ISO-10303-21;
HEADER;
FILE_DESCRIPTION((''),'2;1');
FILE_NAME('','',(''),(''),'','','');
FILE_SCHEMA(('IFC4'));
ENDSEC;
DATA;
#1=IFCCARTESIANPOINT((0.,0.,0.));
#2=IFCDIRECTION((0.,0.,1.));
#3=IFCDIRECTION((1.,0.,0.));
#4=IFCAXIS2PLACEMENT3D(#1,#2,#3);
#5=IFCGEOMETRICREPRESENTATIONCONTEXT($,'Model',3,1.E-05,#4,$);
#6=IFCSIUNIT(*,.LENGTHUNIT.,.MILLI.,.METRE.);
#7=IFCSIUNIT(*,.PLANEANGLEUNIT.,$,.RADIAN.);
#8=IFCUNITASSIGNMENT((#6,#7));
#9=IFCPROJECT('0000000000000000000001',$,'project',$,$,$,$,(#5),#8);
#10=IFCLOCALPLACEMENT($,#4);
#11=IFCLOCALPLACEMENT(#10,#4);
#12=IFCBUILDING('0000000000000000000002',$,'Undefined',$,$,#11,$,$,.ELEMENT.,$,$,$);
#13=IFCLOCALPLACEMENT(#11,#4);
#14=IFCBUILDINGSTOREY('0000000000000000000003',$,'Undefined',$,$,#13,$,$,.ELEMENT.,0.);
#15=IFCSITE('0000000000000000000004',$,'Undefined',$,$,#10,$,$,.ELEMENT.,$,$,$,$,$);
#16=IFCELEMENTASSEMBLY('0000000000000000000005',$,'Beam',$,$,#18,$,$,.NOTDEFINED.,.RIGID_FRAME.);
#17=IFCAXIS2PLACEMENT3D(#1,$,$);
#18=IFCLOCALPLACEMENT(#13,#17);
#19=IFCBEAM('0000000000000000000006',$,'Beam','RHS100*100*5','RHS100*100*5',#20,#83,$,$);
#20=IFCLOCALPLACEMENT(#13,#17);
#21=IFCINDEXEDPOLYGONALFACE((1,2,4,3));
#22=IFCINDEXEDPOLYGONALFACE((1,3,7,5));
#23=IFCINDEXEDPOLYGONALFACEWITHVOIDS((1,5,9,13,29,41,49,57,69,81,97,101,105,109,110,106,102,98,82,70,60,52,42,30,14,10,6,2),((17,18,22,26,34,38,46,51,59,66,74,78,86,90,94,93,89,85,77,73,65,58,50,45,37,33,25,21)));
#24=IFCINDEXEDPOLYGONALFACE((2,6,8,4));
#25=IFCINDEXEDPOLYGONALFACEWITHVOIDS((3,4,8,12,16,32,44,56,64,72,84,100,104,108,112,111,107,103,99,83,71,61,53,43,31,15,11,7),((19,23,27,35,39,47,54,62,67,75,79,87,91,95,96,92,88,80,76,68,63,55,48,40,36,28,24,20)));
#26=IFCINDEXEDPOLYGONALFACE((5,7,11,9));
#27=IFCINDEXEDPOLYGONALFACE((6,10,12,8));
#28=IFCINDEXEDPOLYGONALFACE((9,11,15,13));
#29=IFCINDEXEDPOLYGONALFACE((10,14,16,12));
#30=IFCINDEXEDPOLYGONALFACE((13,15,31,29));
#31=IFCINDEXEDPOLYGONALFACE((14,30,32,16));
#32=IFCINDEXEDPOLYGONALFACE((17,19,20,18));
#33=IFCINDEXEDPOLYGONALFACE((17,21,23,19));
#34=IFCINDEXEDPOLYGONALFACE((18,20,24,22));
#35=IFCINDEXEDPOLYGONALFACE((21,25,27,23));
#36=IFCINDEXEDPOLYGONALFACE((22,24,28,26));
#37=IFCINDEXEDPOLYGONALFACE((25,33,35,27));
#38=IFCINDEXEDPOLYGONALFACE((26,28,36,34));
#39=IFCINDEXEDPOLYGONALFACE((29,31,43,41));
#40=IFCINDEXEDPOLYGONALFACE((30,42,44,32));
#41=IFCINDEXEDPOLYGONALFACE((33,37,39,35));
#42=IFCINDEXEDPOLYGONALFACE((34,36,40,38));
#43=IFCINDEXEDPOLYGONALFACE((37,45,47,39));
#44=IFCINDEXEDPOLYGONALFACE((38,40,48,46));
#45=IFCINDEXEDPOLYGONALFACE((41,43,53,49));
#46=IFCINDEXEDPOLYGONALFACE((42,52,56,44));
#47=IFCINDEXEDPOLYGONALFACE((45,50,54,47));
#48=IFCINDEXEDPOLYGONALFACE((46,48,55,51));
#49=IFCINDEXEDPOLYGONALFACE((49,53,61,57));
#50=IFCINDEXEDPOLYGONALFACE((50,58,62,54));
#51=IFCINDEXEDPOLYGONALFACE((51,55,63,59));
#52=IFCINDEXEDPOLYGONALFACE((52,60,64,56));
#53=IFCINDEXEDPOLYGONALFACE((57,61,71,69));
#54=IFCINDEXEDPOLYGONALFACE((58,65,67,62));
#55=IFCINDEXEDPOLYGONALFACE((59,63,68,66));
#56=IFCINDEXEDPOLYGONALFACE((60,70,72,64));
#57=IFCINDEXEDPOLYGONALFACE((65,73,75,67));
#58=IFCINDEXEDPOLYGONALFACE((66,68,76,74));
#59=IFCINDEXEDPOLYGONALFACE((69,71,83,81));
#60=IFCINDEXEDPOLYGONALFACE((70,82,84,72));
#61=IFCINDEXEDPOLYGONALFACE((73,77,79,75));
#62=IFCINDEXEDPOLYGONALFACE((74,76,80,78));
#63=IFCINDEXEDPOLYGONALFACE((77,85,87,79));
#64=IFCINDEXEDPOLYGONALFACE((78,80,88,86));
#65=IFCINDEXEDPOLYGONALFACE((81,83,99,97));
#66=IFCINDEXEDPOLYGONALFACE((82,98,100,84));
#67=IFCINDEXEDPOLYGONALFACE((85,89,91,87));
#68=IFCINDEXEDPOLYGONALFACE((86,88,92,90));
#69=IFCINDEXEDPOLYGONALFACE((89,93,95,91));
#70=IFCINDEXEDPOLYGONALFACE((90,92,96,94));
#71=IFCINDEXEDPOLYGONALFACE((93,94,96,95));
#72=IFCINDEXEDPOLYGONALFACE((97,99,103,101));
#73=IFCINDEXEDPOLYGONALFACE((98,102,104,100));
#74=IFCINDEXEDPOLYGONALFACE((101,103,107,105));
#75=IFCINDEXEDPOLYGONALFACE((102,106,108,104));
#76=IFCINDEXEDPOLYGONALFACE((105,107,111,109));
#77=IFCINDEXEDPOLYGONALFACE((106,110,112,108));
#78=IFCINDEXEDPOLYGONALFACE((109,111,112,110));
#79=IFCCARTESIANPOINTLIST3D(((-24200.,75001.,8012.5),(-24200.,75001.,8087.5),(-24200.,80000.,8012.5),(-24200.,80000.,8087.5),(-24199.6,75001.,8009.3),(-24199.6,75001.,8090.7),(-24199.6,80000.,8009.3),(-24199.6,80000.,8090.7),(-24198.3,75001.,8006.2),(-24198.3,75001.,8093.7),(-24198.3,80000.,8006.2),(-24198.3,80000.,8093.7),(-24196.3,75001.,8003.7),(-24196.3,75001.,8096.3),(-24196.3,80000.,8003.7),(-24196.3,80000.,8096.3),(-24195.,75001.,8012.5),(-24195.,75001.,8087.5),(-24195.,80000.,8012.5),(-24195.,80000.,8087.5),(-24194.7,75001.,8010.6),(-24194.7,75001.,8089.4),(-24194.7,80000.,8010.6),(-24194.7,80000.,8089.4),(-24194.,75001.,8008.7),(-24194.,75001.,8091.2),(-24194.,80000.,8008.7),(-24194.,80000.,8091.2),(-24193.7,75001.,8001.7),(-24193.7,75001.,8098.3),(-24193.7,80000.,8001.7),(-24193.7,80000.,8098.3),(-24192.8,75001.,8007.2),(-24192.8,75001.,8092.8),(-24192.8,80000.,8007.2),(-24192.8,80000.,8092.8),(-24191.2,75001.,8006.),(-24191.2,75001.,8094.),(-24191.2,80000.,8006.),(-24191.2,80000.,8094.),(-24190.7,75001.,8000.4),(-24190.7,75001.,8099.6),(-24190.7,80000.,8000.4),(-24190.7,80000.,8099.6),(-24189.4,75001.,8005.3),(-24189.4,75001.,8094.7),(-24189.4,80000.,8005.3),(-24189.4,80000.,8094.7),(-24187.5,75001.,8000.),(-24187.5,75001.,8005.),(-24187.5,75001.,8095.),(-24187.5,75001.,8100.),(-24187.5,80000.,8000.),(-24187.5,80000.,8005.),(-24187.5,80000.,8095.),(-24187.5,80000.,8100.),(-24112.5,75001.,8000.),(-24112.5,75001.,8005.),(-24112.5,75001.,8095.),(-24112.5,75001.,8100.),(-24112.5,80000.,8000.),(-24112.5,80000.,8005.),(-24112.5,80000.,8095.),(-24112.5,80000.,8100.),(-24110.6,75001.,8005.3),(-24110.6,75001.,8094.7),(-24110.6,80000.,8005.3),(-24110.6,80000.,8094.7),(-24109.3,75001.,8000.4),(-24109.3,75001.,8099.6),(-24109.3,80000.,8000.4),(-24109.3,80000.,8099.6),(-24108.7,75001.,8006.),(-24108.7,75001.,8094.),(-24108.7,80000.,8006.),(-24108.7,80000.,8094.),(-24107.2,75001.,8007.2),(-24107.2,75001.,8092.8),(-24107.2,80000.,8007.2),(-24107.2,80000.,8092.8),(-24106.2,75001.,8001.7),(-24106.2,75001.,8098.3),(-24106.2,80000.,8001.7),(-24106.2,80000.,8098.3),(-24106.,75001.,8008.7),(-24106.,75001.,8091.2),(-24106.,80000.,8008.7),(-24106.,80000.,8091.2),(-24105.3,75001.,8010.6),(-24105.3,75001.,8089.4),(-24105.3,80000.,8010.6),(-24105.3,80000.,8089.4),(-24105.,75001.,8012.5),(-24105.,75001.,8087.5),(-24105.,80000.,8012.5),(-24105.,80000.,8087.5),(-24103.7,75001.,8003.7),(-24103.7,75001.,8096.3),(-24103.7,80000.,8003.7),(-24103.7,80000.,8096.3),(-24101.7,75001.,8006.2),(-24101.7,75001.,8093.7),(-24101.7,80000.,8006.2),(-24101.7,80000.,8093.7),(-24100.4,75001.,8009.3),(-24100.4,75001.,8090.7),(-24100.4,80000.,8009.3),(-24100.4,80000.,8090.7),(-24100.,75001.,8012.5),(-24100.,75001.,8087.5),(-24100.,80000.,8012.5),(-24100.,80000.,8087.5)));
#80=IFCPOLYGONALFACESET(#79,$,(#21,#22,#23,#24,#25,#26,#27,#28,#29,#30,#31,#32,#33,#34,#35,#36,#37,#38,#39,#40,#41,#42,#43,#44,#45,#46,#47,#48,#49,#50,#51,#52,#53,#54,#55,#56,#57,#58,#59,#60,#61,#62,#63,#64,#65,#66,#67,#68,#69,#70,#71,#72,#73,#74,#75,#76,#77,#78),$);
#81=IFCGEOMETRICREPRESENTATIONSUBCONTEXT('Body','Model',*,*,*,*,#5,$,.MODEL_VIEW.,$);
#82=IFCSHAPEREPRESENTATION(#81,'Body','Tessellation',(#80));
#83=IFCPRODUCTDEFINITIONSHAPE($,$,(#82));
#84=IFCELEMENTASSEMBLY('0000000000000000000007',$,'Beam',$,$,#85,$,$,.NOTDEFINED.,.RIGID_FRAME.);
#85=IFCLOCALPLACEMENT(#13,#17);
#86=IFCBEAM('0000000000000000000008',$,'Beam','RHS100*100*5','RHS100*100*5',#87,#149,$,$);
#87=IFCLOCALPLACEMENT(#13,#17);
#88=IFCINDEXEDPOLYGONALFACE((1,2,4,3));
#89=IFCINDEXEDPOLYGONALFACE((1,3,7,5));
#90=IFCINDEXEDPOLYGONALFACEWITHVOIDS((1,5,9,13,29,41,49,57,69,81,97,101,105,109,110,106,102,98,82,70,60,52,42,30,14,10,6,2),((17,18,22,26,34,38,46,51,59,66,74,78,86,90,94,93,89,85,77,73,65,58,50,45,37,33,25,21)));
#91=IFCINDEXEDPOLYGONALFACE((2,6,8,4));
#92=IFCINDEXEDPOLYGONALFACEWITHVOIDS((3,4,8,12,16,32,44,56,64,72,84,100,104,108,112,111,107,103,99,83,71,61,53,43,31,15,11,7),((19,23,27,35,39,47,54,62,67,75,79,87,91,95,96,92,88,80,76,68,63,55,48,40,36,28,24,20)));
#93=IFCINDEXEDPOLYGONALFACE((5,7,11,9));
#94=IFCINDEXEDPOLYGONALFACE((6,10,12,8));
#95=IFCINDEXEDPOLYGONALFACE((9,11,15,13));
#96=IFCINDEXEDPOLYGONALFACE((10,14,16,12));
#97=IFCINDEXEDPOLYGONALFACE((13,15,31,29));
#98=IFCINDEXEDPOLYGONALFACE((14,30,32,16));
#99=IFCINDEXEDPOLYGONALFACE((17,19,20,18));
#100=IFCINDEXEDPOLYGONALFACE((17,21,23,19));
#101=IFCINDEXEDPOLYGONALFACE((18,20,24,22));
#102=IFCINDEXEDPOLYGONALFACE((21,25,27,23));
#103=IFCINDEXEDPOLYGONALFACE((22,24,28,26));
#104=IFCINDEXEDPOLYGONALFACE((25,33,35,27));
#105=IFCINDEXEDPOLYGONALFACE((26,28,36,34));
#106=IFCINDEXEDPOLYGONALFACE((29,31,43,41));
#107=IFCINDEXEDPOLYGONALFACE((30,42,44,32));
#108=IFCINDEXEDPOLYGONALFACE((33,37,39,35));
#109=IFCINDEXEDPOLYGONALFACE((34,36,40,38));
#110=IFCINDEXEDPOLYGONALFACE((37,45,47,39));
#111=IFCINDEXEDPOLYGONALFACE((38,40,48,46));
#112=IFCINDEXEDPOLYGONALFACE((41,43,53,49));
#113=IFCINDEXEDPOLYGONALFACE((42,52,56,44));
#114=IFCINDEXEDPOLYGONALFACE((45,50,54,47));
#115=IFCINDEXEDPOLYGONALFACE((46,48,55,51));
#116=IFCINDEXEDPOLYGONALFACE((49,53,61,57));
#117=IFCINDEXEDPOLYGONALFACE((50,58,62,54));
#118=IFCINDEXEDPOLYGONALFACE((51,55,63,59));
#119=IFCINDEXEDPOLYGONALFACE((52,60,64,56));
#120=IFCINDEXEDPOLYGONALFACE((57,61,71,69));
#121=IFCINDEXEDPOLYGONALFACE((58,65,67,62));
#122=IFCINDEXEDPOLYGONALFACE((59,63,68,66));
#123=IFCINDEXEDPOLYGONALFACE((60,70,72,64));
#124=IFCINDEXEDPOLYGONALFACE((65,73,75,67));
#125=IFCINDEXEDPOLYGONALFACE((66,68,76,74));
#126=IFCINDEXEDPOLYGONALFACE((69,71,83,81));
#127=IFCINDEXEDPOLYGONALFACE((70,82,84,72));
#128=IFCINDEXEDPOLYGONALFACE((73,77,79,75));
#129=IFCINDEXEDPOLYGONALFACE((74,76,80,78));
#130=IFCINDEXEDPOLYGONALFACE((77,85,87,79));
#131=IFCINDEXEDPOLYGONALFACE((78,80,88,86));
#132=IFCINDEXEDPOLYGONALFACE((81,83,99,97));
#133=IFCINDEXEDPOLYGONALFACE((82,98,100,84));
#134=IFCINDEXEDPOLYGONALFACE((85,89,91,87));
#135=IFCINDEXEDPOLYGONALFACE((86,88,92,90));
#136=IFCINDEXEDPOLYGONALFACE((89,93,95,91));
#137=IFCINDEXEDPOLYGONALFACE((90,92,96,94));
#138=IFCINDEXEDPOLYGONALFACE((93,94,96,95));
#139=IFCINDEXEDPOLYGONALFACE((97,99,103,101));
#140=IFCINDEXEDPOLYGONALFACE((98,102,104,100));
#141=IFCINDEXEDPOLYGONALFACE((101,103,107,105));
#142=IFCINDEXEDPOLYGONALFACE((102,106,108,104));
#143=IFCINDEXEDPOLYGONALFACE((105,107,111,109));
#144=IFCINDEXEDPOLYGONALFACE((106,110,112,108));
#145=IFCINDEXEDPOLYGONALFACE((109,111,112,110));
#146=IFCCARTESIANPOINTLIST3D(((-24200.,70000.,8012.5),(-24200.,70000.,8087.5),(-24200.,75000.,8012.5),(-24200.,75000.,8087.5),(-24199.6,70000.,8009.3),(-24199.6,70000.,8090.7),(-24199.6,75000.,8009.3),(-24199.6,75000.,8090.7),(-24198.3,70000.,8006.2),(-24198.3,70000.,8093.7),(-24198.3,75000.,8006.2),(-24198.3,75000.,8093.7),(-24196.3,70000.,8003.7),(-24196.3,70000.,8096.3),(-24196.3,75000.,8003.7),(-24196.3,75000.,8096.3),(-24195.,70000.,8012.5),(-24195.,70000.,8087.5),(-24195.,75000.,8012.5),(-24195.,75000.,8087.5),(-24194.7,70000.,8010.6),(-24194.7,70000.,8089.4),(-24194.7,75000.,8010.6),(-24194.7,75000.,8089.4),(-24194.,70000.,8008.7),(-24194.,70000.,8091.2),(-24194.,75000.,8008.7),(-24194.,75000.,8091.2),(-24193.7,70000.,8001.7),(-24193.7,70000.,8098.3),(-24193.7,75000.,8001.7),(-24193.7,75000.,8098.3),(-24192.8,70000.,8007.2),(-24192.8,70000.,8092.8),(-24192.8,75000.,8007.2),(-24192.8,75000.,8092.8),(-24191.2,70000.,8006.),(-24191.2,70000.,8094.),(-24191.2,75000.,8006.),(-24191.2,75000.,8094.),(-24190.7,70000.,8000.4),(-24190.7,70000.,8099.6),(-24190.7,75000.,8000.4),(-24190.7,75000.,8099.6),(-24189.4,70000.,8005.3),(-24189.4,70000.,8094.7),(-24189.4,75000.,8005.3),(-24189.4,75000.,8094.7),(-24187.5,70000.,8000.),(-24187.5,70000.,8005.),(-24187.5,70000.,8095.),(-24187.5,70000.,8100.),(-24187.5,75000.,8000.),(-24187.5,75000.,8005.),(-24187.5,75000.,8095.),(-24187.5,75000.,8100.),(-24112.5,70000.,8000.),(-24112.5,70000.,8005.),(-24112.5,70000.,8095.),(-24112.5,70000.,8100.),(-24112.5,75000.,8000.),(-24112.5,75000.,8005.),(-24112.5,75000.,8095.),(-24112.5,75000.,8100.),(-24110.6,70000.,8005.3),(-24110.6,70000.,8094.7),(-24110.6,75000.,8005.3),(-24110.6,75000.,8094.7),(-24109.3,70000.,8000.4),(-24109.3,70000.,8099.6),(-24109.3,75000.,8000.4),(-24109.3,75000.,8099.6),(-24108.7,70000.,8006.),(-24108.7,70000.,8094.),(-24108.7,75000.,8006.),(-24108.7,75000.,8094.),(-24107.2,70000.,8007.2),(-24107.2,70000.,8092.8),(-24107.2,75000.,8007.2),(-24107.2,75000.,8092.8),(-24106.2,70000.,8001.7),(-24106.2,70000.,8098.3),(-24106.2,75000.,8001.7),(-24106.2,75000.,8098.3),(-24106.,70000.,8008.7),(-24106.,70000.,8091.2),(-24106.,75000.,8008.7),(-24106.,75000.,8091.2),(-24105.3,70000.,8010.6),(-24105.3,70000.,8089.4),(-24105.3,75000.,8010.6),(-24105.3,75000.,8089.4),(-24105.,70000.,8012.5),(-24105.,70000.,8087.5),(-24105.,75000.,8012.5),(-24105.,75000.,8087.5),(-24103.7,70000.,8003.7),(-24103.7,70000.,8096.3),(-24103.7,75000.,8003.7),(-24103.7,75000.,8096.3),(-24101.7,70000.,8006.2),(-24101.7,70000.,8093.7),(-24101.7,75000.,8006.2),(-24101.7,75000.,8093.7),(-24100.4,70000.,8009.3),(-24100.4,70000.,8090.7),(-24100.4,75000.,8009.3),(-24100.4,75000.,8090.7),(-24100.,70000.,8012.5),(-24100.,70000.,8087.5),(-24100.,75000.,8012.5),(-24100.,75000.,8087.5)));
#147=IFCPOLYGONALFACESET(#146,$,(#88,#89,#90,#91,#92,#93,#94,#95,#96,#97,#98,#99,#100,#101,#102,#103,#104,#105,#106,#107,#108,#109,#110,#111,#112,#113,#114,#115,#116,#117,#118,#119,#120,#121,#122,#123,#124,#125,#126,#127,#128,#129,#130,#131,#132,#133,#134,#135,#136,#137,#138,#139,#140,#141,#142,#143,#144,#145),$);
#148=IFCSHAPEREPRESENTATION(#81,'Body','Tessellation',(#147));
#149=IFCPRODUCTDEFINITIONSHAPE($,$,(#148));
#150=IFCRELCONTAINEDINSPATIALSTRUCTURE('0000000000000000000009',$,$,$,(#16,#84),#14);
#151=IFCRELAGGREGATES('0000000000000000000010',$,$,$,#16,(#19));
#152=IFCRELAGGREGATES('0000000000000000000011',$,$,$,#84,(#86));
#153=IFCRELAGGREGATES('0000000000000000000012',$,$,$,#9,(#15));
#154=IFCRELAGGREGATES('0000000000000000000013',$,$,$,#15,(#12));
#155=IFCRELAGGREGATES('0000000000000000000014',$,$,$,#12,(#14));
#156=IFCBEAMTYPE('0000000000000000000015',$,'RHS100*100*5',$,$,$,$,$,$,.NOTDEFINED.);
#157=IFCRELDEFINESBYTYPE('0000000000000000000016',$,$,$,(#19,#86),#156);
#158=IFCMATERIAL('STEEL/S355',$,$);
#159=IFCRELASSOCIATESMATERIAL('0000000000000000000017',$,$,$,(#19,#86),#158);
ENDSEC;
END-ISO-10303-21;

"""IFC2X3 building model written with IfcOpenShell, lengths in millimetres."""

from ifc_helpers import new_model, si_unit, frame, origin_with_axes, origin_2d_with_axis, place, context, subcontext, project, spatial, hollow_rectangle, extrude, material, type_object, element, aggregate, save


model = new_model("IFC2X3")

# Units and contexts
model_context = context("Model", 3, precision=1e-05, world=origin_with_axes())
body_context = subcontext(model_context, "Body", "Model", "MODEL_VIEW")
ifc_project = project(units=[si_unit("LENGTHUNIT", "METRE", prefix="MILLI"), si_unit("PLANEANGLEUNIT", "RADIAN")], contexts=[model_context])

# Site, building, storey
site_placement = place(None, origin_with_axes())
site = spatial("IfcSite", under=ifc_project, at=site_placement, Name="Undefined", CompositionType="ELEMENT")
building_placement = place(site_placement, origin_with_axes())
building = spatial("IfcBuilding", under=site, at=building_placement, Name="Undefined", CompositionType="ELEMENT")
storey_placement = place(building_placement, origin_with_axes())
storey = spatial("IfcBuildingStorey", under=building, at=storey_placement, Name="Undefined", CompositionType="ELEMENT", Elevation=0.0)

# Element assemblies, beams
assembly_1_placement = place(storey_placement, origin_with_axes())
assembly_1 = element("IfcElementAssembly", 1, at=assembly_1_placement, inside=storey, Name="Beam", AssemblyPlace="NOTDEFINED", PredefinedType="RIGID_FRAME")
ifc_material_1 = material(Name="STEEL/S355")
beam_type_1 = type_object("IfcBeamType", Name="RHS100*100*5", PredefinedType="NOTDEFINED")
beam_1_placement = place(assembly_1_placement, frame((-24150.0, 75001.0, 8050.0), z_axis=(0.0, 0.0, 1.0), x_axis=(0.0, 1.0, 0.0)))
beam_1 = element("IfcBeam", 2, at=beam_1_placement, type_object=beam_type_1, material=ifc_material_1, Name="Beam", Description="RHS100*100*5", ObjectType="RHS100*100*5", context=body_context, shape_type="SweptSolid", body=[
    extrude(hollow_rectangle(XDim=100.0, YDim=100.0, WallThickness=5.0, InnerFilletRadius=7.5, OuterFilletRadius=12.5, at=origin_2d_with_axis()), frame((4999.0, 0.0, 0.0), z_axis=(-1.0, 0.0, 0.0), x_axis=(0.0, -1.0, 0.0)), (0.0, 0.0, 1.0), 4999.0),
])
aggregate(assembly_1, [beam_1])
assembly_2_placement = place(storey_placement, origin_with_axes())
assembly_2 = element("IfcElementAssembly", 3, at=assembly_2_placement, inside=storey, Name="Beam", AssemblyPlace="NOTDEFINED", PredefinedType="RIGID_FRAME")
beam_2_placement = place(assembly_2_placement, frame((-24150.0, 70000.0, 8050.0), z_axis=(0.0, 0.0, 1.0), x_axis=(0.0, 1.0, 0.0)))
beam_2 = element("IfcBeam", 4, at=beam_2_placement, type_object=beam_type_1, material=ifc_material_1, Name="Beam", Description="RHS100*100*5", ObjectType="RHS100*100*5", context=body_context, shape_type="SweptSolid", body=[
    extrude(hollow_rectangle(XDim=100.0, YDim=100.0, WallThickness=5.0, InnerFilletRadius=7.5, OuterFilletRadius=12.5, at=origin_2d_with_axis()), frame((5000.0, 0.0, 0.0), z_axis=(-1.0, 0.0, 0.0), x_axis=(0.0, -1.0, 0.0)), (0.0, 0.0, 1.0), 5000.0),
])
aggregate(assembly_2, [beam_2])

save(model, "model.ifc")
